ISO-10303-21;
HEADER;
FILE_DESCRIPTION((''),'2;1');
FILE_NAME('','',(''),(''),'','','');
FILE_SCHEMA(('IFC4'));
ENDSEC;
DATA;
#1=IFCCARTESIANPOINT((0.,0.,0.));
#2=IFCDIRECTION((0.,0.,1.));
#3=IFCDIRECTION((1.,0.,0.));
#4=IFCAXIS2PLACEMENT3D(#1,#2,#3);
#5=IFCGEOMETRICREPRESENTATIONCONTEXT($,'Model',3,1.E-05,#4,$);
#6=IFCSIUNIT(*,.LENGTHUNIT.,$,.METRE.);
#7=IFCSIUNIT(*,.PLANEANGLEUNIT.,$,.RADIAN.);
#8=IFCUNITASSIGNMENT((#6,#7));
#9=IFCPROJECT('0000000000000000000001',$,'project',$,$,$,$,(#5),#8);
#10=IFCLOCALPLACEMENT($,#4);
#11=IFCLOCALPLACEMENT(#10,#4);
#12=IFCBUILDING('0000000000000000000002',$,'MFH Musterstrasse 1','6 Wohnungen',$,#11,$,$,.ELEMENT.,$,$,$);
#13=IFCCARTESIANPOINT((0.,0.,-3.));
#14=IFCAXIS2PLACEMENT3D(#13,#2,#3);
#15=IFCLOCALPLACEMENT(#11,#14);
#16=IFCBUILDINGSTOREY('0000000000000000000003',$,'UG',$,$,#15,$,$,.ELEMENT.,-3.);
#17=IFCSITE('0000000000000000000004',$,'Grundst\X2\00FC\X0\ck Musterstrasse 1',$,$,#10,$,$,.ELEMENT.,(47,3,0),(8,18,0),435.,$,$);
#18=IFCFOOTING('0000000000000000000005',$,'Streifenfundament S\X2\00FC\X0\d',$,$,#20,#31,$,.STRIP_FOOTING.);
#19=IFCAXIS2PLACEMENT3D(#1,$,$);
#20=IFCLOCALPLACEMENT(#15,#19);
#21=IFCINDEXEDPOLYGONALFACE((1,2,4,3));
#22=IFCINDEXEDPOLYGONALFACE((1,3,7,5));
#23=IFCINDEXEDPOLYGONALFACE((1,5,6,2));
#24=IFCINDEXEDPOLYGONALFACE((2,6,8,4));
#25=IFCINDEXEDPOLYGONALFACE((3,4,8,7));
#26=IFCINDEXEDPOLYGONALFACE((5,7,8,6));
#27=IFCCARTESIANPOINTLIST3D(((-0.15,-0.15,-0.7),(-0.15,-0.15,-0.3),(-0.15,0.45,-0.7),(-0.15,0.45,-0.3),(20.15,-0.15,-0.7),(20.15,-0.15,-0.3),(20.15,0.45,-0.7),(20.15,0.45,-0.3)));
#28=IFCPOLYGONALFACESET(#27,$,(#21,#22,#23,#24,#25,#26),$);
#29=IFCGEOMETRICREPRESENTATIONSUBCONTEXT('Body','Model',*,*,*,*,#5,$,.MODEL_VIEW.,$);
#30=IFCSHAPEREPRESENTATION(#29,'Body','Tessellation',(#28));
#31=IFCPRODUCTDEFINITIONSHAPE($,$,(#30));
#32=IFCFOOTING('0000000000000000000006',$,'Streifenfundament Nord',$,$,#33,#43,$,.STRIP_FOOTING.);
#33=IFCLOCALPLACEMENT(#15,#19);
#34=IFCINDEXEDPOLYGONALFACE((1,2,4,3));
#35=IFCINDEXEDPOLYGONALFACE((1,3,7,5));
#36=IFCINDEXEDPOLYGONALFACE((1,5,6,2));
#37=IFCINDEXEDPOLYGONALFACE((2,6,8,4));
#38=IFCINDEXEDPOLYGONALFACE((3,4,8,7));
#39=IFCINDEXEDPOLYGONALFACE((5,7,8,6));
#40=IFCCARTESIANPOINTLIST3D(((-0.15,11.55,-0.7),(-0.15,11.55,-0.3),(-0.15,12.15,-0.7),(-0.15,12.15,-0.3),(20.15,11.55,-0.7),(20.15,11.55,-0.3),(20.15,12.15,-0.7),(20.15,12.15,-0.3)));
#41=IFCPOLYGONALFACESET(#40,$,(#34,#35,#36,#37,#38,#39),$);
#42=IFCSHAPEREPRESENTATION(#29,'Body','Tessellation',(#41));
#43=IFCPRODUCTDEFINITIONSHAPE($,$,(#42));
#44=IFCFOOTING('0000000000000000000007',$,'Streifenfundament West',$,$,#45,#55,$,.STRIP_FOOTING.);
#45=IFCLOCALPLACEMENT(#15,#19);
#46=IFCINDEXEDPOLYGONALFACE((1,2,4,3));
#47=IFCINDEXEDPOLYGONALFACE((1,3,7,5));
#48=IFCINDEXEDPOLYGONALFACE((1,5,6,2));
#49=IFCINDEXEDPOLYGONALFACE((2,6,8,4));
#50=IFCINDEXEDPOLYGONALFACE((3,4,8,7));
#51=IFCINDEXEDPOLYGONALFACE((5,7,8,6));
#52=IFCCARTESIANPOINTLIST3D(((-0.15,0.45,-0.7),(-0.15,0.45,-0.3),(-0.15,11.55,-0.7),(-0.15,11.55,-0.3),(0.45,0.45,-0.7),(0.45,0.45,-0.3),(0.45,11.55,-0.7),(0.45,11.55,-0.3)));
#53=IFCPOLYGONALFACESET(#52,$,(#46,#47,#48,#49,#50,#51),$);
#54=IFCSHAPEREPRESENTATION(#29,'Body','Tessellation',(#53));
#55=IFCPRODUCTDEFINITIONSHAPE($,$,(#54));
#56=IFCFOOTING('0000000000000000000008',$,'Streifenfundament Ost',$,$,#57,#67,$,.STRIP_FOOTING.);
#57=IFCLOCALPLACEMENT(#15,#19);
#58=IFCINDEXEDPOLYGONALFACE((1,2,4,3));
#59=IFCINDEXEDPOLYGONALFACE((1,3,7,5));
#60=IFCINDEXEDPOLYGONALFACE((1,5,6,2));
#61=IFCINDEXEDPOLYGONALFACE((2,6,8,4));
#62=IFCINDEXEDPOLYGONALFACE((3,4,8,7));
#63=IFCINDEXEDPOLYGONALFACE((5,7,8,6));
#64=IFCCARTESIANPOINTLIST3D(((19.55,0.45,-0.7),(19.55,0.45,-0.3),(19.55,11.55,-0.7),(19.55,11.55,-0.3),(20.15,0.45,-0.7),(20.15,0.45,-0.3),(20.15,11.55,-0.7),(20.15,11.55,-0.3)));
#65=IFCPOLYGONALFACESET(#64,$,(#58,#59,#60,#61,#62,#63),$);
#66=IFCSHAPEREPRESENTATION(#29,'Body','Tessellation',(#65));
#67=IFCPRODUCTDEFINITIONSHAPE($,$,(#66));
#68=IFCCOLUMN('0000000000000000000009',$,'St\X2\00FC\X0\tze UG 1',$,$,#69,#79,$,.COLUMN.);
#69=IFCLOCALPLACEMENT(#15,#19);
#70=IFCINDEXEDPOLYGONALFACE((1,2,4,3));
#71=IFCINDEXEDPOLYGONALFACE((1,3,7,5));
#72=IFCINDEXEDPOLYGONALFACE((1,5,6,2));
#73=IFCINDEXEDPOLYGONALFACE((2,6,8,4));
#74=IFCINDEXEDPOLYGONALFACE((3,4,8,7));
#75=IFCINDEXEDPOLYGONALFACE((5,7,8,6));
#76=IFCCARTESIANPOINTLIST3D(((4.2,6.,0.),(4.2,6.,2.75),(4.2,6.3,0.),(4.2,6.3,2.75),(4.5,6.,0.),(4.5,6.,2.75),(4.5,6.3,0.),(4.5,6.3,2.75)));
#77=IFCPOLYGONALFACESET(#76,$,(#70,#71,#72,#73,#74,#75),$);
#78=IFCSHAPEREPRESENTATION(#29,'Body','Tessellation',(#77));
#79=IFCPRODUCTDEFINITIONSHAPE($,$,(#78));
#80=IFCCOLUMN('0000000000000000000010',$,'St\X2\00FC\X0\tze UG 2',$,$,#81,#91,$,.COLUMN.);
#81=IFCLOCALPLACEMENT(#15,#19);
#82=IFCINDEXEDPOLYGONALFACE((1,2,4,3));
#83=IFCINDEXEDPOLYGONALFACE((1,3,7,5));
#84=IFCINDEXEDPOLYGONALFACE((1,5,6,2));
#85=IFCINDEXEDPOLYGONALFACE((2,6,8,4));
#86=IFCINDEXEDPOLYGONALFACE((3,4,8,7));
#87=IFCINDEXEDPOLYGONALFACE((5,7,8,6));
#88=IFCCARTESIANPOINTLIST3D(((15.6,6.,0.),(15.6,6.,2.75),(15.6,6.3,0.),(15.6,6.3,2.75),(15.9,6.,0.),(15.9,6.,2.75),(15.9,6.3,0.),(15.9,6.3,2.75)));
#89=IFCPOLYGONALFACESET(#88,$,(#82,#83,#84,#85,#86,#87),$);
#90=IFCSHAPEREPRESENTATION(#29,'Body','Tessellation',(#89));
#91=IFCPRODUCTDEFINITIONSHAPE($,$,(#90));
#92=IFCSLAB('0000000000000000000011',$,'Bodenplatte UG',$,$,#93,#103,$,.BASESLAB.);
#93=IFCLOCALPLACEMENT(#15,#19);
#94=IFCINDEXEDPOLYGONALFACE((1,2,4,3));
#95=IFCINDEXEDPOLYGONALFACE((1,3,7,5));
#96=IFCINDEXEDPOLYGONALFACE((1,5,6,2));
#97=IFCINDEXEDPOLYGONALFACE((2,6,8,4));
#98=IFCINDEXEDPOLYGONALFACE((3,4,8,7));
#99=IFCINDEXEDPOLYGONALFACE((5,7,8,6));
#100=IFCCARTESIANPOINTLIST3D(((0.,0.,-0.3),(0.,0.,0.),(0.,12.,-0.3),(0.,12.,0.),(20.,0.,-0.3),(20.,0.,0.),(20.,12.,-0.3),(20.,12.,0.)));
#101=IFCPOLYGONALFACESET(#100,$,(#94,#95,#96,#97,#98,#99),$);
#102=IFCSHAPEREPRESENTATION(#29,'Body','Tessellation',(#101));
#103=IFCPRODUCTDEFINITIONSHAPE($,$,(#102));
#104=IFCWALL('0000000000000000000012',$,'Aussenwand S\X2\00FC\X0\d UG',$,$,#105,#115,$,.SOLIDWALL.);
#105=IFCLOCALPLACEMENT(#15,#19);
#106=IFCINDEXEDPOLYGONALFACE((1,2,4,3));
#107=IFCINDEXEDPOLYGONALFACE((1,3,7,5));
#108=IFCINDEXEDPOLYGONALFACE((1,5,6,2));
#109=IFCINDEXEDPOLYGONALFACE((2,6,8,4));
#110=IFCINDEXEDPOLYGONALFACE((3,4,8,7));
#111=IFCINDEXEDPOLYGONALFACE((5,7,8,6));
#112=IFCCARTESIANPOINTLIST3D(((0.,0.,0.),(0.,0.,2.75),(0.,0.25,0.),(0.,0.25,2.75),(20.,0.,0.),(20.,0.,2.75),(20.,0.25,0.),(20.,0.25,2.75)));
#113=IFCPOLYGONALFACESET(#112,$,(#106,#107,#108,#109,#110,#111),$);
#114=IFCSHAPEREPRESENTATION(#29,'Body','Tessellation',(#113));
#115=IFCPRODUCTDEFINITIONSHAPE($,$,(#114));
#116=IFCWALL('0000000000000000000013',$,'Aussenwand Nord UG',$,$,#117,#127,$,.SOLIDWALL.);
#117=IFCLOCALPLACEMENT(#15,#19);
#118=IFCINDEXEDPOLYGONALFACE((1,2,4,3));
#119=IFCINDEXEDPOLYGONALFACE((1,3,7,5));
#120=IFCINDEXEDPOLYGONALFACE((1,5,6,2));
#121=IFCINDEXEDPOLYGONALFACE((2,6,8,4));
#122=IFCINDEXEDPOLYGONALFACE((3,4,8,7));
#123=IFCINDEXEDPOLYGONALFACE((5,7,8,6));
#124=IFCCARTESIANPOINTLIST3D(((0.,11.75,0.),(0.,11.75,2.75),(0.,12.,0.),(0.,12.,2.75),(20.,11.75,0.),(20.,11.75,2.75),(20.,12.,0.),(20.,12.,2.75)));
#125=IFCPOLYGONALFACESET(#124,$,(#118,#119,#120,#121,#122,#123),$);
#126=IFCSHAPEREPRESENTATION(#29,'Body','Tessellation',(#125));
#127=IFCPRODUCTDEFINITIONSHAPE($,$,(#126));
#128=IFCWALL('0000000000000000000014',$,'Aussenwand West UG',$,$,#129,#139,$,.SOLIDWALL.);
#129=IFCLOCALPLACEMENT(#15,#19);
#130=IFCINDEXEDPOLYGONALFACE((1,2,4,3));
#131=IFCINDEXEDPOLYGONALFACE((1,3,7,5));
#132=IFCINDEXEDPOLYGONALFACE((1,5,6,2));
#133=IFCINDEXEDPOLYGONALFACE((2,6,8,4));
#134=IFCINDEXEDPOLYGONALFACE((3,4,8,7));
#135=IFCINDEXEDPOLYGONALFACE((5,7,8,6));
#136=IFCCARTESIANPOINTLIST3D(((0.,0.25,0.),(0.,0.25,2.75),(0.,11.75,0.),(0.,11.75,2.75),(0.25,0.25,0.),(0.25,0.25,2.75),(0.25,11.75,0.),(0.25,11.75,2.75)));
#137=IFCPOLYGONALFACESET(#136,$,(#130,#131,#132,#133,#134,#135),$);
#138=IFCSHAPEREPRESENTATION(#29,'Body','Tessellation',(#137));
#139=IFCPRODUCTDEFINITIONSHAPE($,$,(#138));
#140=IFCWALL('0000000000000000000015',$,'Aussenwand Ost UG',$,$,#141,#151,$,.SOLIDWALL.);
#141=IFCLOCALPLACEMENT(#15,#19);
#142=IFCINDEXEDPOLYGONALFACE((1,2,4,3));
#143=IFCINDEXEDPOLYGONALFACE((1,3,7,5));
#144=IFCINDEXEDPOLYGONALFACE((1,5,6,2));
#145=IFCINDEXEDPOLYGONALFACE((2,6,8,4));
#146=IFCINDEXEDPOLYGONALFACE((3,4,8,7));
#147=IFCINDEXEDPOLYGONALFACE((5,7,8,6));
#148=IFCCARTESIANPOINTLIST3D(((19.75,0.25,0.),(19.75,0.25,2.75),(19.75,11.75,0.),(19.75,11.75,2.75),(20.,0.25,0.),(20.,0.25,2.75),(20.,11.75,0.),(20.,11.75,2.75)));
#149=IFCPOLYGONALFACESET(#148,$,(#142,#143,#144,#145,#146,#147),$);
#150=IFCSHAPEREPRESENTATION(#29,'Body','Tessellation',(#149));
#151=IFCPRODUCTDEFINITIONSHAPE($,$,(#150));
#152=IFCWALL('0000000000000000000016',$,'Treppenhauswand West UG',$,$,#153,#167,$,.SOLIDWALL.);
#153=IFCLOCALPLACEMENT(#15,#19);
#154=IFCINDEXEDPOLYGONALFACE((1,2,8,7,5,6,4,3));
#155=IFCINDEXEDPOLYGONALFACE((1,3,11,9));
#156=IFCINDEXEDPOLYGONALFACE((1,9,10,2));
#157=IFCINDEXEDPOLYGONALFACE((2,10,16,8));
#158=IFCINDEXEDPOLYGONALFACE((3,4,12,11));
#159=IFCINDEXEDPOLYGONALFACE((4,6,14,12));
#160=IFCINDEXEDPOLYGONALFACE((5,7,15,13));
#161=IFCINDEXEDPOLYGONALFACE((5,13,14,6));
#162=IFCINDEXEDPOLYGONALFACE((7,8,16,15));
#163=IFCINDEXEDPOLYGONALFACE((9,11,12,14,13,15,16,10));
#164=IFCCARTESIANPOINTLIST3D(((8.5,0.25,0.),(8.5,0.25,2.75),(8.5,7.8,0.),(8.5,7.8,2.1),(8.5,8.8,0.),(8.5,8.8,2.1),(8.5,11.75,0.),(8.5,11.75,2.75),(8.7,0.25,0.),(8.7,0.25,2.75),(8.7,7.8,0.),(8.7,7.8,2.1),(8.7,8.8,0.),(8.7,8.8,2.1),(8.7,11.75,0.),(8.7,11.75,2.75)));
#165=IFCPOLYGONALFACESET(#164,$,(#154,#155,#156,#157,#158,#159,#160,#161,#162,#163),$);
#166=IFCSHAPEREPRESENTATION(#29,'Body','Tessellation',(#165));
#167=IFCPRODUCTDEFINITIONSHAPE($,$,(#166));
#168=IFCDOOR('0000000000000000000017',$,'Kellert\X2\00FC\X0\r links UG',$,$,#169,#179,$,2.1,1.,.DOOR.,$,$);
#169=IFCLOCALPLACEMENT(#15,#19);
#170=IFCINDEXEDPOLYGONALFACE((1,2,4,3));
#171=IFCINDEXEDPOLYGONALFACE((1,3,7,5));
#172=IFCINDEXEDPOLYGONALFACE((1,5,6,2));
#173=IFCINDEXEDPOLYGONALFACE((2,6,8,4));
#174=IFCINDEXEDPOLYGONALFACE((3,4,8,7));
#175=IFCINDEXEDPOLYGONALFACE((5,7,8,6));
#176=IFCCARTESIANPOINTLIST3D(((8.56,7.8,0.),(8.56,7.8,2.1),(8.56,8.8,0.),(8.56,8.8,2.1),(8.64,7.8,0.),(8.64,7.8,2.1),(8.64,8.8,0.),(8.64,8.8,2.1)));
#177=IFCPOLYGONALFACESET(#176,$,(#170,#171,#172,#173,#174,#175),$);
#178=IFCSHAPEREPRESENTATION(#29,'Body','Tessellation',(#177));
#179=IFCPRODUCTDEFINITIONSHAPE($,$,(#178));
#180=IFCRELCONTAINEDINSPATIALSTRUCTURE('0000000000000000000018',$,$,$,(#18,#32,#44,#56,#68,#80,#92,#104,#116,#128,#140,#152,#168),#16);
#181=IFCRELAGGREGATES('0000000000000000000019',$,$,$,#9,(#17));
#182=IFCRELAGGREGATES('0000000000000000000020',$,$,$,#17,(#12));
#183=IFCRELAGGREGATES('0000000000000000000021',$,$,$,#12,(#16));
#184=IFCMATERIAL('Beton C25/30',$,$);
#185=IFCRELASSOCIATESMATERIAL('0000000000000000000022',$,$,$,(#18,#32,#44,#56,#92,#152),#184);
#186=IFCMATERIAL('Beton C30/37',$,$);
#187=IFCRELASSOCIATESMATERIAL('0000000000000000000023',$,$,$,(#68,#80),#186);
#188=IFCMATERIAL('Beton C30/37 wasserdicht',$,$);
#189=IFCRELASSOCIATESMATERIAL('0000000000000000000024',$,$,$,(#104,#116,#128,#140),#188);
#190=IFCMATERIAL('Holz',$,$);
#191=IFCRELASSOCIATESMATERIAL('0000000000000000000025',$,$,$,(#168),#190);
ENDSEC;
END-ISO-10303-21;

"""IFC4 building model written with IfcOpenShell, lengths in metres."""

from ifc_helpers import new_model, si_unit, frame, frame_2d, origin_with_axes, place, context, subcontext, project, spatial, rectangle, extrude, material, element, fill, save


model = new_model("IFC4")

# Units and contexts
model_context = context("Model", 3, precision=1e-05, world=origin_with_axes())
body_context = subcontext(model_context, "Body", "Model", "MODEL_VIEW")
ifc_project = project(units=[si_unit("LENGTHUNIT", "METRE"), si_unit("PLANEANGLEUNIT", "RADIAN")], contexts=[model_context])

# Site, building, storey
site_placement = place(None, origin_with_axes())
site = spatial("IfcSite", under=ifc_project, at=site_placement, Name="Grundstück Musterstrasse 1", CompositionType="ELEMENT", RefLatitude=(47, 3, 0), RefLongitude=(8, 18, 0), RefElevation=435.0)
building_placement = place(site_placement, origin_with_axes())
building = spatial("IfcBuilding", under=site, at=building_placement, Name="MFH Musterstrasse 1", Description="6 Wohnungen", CompositionType="ELEMENT")
storey_placement = place(building_placement, frame((0.0, 0.0, -3.0), z_axis=(0.0, 0.0, 1.0), x_axis=(1.0, 0.0, 0.0)))
storey = spatial("IfcBuildingStorey", under=building, at=storey_placement, Name="UG", CompositionType="ELEMENT", Elevation=-3.0)

# Footings
ifc_material_1 = material(Name="Beton C25/30")
footing_1_placement = place(storey_placement, origin_with_axes())
element("IfcFooting", 1, at=footing_1_placement, inside=storey, material=ifc_material_1, Name="Streifenfundament Süd", PredefinedType="STRIP_FOOTING", context=body_context, shape_type="SweptSolid", body=[
    extrude(rectangle(XDim=20.3, YDim=0.6, at=frame_2d((10.15, 0.3), x_axis=(1.0, 0.0))), frame((-0.15, -0.15, -0.7), z_axis=(0.0, 0.0, 1.0), x_axis=(1.0, 0.0, 0.0)), (0.0, 0.0, 1.0), 0.4),
])
footing_2_placement = place(storey_placement, origin_with_axes())
element("IfcFooting", 2, at=footing_2_placement, inside=storey, material=ifc_material_1, Name="Streifenfundament Nord", PredefinedType="STRIP_FOOTING", context=body_context, shape_type="SweptSolid", body=[
    extrude(rectangle(XDim=20.3, YDim=0.6, at=frame_2d((10.15, 0.3), x_axis=(1.0, 0.0))), frame((-0.15, 11.55, -0.7), z_axis=(0.0, 0.0, 1.0), x_axis=(1.0, 0.0, 0.0)), (0.0, 0.0, 1.0), 0.4),
])
footing_3_placement = place(storey_placement, origin_with_axes())
element("IfcFooting", 3, at=footing_3_placement, inside=storey, material=ifc_material_1, Name="Streifenfundament West", PredefinedType="STRIP_FOOTING", context=body_context, shape_type="SweptSolid", body=[
    extrude(rectangle(XDim=0.6, YDim=11.1, at=frame_2d((0.3, 5.55), x_axis=(1.0, 0.0))), frame((-0.15, 0.45, -0.7), z_axis=(0.0, 0.0, 1.0), x_axis=(1.0, 0.0, 0.0)), (0.0, 0.0, 1.0), 0.4),
])
footing_4_placement = place(storey_placement, origin_with_axes())
element("IfcFooting", 4, at=footing_4_placement, inside=storey, material=ifc_material_1, Name="Streifenfundament Ost", PredefinedType="STRIP_FOOTING", context=body_context, shape_type="SweptSolid", body=[
    extrude(rectangle(XDim=0.6, YDim=11.1, at=frame_2d((0.3, 5.55), x_axis=(1.0, 0.0))), frame((19.55, 0.45, -0.7), z_axis=(0.0, 0.0, 1.0), x_axis=(1.0, 0.0, 0.0)), (0.0, 0.0, 1.0), 0.4),
])

# Columns
ifc_material_2 = material(Name="Beton C30/37")
column_1_placement = place(storey_placement, origin_with_axes())
element("IfcColumn", 5, at=column_1_placement, inside=storey, material=ifc_material_2, Name="Stütze UG 1", PredefinedType="COLUMN", context=body_context, shape_type="SweptSolid", body=[
    extrude(rectangle(XDim=0.3, YDim=0.3, at=frame_2d((0.15, 0.15), x_axis=(1.0, 0.0))), frame((4.2, 6.0, 0.0), z_axis=(0.0, 0.0, 1.0), x_axis=(1.0, 0.0, 0.0)), (0.0, 0.0, 1.0), 2.75),
])
column_2_placement = place(storey_placement, origin_with_axes())
element("IfcColumn", 6, at=column_2_placement, inside=storey, material=ifc_material_2, Name="Stütze UG 2", PredefinedType="COLUMN", context=body_context, shape_type="SweptSolid", body=[
    extrude(rectangle(XDim=0.3, YDim=0.3, at=frame_2d((0.15, 0.15), x_axis=(1.0, 0.0))), frame((15.6, 6.0, 0.0), z_axis=(0.0, 0.0, 1.0), x_axis=(1.0, 0.0, 0.0)), (0.0, 0.0, 1.0), 2.75),
])

# Slab
slab_placement = place(storey_placement, origin_with_axes())
element("IfcSlab", 7, at=slab_placement, inside=storey, material=ifc_material_1, Name="Bodenplatte UG", PredefinedType="BASESLAB", context=body_context, shape_type="SweptSolid", body=[
    extrude(rectangle(XDim=20.0, YDim=12.0, at=frame_2d((10.0, 6.0), x_axis=(1.0, 0.0))), frame((0.0, 0.0, -0.3), z_axis=(0.0, 0.0, 1.0), x_axis=(1.0, 0.0, 0.0)), (0.0, 0.0, 1.0), 0.3),
])

# Walls
ifc_material_3 = material(Name="Beton C30/37 wasserdicht")
wall_1_placement = place(storey_placement, origin_with_axes())
element("IfcWall", 8, at=wall_1_placement, inside=storey, material=ifc_material_3, Name="Aussenwand Süd UG", PredefinedType="SOLIDWALL", context=body_context, shape_type="SweptSolid", body=[
    extrude(rectangle(XDim=20.0, YDim=0.25, at=frame_2d((10.0, 0.125), x_axis=(1.0, 0.0))), origin_with_axes(), (0.0, 0.0, 1.0), 2.75),
])
wall_2_placement = place(storey_placement, origin_with_axes())
element("IfcWall", 9, at=wall_2_placement, inside=storey, material=ifc_material_3, Name="Aussenwand Nord UG", PredefinedType="SOLIDWALL", context=body_context, shape_type="SweptSolid", body=[
    extrude(rectangle(XDim=20.0, YDim=0.25, at=frame_2d((10.0, 0.125), x_axis=(1.0, 0.0))), frame((0.0, 11.75, 0.0), z_axis=(0.0, 0.0, 1.0), x_axis=(1.0, 0.0, 0.0)), (0.0, 0.0, 1.0), 2.75),
])
wall_3_placement = place(storey_placement, origin_with_axes())
element("IfcWall", 10, at=wall_3_placement, inside=storey, material=ifc_material_3, Name="Aussenwand West UG", PredefinedType="SOLIDWALL", context=body_context, shape_type="SweptSolid", body=[
    extrude(rectangle(XDim=0.25, YDim=11.5, at=frame_2d((0.125, 5.75), x_axis=(1.0, 0.0))), frame((0.0, 0.25, 0.0), z_axis=(0.0, 0.0, 1.0), x_axis=(1.0, 0.0, 0.0)), (0.0, 0.0, 1.0), 2.75),
])
wall_4_placement = place(storey_placement, origin_with_axes())
element("IfcWall", 11, at=wall_4_placement, inside=storey, material=ifc_material_3, Name="Aussenwand Ost UG", PredefinedType="SOLIDWALL", context=body_context, shape_type="SweptSolid", body=[
    extrude(rectangle(XDim=0.25, YDim=11.5, at=frame_2d((0.125, 5.75), x_axis=(1.0, 0.0))), frame((19.75, 0.25, 0.0), z_axis=(0.0, 0.0, 1.0), x_axis=(1.0, 0.0, 0.0)), (0.0, 0.0, 1.0), 2.75),
])

# Wall, openings, door
wall_5_placement = place(storey_placement, origin_with_axes())
wall_5 = element("IfcWall", 12, at=wall_5_placement, inside=storey, material=ifc_material_1, Name="Treppenhauswand West UG", PredefinedType="SOLIDWALL", context=body_context, shape_type="SweptSolid", body=[
    extrude(rectangle(XDim=0.2, YDim=11.5, at=frame_2d((0.1, 5.75), x_axis=(1.0, 0.0))), frame((8.5, 0.25, 0.0), z_axis=(0.0, 0.0, 1.0), x_axis=(1.0, 0.0, 0.0)), (0.0, 0.0, 1.0), 2.75),
])
opening_1_placement = place(storey_placement, origin_with_axes())
element("IfcOpeningElement", 13, at=opening_1_placement, cuts=wall_5, PredefinedType="OPENING", context=body_context, shape_type="SweptSolid", body=[
    extrude(rectangle(XDim=0.3, YDim=1.0, at=frame_2d((0.15, 0.5), x_axis=(1.0, 0.0))), frame((8.45, 7.8, 0.0), z_axis=(0.0, 0.0, 1.0), x_axis=(1.0, 0.0, 0.0)), (0.0, 0.0, 1.0), 2.1),
])
opening_2_placement = place(storey_placement, origin_with_axes())
opening_2 = element("IfcOpeningElement", 14, at=opening_2_placement, cuts=wall_5, PredefinedType="OPENING", context=body_context, shape_type="SweptSolid", body=[
    extrude(rectangle(XDim=0.22, YDim=1.0, at=frame_2d((0.11, 0.5), x_axis=(1.0, 0.0))), frame((8.49, 7.8, 0.0), z_axis=(0.0, 0.0, 1.0), x_axis=(1.0, 0.0, 0.0)), (0.0, 0.0, 1.0), 2.1),
])
ifc_material_4 = material(Name="Holz")
door_1_placement = place(storey_placement, origin_with_axes())
door_1 = element("IfcDoor", 15, at=door_1_placement, inside=storey, material=ifc_material_4, Name="Kellertür links UG", OverallHeight=2.1, OverallWidth=1.0, PredefinedType="DOOR", context=body_context, shape_type="SweptSolid", body=[
    extrude(rectangle(XDim=0.08, YDim=1.0, at=frame_2d((0.04, 0.5), x_axis=(1.0, 0.0))), frame((8.56, 7.8, 0.0), z_axis=(0.0, 0.0, 1.0), x_axis=(1.0, 0.0, 0.0)), (0.0, 0.0, 1.0), 2.1),
])
fill(opening_2, door_1)

save(model, "model.ifc")
